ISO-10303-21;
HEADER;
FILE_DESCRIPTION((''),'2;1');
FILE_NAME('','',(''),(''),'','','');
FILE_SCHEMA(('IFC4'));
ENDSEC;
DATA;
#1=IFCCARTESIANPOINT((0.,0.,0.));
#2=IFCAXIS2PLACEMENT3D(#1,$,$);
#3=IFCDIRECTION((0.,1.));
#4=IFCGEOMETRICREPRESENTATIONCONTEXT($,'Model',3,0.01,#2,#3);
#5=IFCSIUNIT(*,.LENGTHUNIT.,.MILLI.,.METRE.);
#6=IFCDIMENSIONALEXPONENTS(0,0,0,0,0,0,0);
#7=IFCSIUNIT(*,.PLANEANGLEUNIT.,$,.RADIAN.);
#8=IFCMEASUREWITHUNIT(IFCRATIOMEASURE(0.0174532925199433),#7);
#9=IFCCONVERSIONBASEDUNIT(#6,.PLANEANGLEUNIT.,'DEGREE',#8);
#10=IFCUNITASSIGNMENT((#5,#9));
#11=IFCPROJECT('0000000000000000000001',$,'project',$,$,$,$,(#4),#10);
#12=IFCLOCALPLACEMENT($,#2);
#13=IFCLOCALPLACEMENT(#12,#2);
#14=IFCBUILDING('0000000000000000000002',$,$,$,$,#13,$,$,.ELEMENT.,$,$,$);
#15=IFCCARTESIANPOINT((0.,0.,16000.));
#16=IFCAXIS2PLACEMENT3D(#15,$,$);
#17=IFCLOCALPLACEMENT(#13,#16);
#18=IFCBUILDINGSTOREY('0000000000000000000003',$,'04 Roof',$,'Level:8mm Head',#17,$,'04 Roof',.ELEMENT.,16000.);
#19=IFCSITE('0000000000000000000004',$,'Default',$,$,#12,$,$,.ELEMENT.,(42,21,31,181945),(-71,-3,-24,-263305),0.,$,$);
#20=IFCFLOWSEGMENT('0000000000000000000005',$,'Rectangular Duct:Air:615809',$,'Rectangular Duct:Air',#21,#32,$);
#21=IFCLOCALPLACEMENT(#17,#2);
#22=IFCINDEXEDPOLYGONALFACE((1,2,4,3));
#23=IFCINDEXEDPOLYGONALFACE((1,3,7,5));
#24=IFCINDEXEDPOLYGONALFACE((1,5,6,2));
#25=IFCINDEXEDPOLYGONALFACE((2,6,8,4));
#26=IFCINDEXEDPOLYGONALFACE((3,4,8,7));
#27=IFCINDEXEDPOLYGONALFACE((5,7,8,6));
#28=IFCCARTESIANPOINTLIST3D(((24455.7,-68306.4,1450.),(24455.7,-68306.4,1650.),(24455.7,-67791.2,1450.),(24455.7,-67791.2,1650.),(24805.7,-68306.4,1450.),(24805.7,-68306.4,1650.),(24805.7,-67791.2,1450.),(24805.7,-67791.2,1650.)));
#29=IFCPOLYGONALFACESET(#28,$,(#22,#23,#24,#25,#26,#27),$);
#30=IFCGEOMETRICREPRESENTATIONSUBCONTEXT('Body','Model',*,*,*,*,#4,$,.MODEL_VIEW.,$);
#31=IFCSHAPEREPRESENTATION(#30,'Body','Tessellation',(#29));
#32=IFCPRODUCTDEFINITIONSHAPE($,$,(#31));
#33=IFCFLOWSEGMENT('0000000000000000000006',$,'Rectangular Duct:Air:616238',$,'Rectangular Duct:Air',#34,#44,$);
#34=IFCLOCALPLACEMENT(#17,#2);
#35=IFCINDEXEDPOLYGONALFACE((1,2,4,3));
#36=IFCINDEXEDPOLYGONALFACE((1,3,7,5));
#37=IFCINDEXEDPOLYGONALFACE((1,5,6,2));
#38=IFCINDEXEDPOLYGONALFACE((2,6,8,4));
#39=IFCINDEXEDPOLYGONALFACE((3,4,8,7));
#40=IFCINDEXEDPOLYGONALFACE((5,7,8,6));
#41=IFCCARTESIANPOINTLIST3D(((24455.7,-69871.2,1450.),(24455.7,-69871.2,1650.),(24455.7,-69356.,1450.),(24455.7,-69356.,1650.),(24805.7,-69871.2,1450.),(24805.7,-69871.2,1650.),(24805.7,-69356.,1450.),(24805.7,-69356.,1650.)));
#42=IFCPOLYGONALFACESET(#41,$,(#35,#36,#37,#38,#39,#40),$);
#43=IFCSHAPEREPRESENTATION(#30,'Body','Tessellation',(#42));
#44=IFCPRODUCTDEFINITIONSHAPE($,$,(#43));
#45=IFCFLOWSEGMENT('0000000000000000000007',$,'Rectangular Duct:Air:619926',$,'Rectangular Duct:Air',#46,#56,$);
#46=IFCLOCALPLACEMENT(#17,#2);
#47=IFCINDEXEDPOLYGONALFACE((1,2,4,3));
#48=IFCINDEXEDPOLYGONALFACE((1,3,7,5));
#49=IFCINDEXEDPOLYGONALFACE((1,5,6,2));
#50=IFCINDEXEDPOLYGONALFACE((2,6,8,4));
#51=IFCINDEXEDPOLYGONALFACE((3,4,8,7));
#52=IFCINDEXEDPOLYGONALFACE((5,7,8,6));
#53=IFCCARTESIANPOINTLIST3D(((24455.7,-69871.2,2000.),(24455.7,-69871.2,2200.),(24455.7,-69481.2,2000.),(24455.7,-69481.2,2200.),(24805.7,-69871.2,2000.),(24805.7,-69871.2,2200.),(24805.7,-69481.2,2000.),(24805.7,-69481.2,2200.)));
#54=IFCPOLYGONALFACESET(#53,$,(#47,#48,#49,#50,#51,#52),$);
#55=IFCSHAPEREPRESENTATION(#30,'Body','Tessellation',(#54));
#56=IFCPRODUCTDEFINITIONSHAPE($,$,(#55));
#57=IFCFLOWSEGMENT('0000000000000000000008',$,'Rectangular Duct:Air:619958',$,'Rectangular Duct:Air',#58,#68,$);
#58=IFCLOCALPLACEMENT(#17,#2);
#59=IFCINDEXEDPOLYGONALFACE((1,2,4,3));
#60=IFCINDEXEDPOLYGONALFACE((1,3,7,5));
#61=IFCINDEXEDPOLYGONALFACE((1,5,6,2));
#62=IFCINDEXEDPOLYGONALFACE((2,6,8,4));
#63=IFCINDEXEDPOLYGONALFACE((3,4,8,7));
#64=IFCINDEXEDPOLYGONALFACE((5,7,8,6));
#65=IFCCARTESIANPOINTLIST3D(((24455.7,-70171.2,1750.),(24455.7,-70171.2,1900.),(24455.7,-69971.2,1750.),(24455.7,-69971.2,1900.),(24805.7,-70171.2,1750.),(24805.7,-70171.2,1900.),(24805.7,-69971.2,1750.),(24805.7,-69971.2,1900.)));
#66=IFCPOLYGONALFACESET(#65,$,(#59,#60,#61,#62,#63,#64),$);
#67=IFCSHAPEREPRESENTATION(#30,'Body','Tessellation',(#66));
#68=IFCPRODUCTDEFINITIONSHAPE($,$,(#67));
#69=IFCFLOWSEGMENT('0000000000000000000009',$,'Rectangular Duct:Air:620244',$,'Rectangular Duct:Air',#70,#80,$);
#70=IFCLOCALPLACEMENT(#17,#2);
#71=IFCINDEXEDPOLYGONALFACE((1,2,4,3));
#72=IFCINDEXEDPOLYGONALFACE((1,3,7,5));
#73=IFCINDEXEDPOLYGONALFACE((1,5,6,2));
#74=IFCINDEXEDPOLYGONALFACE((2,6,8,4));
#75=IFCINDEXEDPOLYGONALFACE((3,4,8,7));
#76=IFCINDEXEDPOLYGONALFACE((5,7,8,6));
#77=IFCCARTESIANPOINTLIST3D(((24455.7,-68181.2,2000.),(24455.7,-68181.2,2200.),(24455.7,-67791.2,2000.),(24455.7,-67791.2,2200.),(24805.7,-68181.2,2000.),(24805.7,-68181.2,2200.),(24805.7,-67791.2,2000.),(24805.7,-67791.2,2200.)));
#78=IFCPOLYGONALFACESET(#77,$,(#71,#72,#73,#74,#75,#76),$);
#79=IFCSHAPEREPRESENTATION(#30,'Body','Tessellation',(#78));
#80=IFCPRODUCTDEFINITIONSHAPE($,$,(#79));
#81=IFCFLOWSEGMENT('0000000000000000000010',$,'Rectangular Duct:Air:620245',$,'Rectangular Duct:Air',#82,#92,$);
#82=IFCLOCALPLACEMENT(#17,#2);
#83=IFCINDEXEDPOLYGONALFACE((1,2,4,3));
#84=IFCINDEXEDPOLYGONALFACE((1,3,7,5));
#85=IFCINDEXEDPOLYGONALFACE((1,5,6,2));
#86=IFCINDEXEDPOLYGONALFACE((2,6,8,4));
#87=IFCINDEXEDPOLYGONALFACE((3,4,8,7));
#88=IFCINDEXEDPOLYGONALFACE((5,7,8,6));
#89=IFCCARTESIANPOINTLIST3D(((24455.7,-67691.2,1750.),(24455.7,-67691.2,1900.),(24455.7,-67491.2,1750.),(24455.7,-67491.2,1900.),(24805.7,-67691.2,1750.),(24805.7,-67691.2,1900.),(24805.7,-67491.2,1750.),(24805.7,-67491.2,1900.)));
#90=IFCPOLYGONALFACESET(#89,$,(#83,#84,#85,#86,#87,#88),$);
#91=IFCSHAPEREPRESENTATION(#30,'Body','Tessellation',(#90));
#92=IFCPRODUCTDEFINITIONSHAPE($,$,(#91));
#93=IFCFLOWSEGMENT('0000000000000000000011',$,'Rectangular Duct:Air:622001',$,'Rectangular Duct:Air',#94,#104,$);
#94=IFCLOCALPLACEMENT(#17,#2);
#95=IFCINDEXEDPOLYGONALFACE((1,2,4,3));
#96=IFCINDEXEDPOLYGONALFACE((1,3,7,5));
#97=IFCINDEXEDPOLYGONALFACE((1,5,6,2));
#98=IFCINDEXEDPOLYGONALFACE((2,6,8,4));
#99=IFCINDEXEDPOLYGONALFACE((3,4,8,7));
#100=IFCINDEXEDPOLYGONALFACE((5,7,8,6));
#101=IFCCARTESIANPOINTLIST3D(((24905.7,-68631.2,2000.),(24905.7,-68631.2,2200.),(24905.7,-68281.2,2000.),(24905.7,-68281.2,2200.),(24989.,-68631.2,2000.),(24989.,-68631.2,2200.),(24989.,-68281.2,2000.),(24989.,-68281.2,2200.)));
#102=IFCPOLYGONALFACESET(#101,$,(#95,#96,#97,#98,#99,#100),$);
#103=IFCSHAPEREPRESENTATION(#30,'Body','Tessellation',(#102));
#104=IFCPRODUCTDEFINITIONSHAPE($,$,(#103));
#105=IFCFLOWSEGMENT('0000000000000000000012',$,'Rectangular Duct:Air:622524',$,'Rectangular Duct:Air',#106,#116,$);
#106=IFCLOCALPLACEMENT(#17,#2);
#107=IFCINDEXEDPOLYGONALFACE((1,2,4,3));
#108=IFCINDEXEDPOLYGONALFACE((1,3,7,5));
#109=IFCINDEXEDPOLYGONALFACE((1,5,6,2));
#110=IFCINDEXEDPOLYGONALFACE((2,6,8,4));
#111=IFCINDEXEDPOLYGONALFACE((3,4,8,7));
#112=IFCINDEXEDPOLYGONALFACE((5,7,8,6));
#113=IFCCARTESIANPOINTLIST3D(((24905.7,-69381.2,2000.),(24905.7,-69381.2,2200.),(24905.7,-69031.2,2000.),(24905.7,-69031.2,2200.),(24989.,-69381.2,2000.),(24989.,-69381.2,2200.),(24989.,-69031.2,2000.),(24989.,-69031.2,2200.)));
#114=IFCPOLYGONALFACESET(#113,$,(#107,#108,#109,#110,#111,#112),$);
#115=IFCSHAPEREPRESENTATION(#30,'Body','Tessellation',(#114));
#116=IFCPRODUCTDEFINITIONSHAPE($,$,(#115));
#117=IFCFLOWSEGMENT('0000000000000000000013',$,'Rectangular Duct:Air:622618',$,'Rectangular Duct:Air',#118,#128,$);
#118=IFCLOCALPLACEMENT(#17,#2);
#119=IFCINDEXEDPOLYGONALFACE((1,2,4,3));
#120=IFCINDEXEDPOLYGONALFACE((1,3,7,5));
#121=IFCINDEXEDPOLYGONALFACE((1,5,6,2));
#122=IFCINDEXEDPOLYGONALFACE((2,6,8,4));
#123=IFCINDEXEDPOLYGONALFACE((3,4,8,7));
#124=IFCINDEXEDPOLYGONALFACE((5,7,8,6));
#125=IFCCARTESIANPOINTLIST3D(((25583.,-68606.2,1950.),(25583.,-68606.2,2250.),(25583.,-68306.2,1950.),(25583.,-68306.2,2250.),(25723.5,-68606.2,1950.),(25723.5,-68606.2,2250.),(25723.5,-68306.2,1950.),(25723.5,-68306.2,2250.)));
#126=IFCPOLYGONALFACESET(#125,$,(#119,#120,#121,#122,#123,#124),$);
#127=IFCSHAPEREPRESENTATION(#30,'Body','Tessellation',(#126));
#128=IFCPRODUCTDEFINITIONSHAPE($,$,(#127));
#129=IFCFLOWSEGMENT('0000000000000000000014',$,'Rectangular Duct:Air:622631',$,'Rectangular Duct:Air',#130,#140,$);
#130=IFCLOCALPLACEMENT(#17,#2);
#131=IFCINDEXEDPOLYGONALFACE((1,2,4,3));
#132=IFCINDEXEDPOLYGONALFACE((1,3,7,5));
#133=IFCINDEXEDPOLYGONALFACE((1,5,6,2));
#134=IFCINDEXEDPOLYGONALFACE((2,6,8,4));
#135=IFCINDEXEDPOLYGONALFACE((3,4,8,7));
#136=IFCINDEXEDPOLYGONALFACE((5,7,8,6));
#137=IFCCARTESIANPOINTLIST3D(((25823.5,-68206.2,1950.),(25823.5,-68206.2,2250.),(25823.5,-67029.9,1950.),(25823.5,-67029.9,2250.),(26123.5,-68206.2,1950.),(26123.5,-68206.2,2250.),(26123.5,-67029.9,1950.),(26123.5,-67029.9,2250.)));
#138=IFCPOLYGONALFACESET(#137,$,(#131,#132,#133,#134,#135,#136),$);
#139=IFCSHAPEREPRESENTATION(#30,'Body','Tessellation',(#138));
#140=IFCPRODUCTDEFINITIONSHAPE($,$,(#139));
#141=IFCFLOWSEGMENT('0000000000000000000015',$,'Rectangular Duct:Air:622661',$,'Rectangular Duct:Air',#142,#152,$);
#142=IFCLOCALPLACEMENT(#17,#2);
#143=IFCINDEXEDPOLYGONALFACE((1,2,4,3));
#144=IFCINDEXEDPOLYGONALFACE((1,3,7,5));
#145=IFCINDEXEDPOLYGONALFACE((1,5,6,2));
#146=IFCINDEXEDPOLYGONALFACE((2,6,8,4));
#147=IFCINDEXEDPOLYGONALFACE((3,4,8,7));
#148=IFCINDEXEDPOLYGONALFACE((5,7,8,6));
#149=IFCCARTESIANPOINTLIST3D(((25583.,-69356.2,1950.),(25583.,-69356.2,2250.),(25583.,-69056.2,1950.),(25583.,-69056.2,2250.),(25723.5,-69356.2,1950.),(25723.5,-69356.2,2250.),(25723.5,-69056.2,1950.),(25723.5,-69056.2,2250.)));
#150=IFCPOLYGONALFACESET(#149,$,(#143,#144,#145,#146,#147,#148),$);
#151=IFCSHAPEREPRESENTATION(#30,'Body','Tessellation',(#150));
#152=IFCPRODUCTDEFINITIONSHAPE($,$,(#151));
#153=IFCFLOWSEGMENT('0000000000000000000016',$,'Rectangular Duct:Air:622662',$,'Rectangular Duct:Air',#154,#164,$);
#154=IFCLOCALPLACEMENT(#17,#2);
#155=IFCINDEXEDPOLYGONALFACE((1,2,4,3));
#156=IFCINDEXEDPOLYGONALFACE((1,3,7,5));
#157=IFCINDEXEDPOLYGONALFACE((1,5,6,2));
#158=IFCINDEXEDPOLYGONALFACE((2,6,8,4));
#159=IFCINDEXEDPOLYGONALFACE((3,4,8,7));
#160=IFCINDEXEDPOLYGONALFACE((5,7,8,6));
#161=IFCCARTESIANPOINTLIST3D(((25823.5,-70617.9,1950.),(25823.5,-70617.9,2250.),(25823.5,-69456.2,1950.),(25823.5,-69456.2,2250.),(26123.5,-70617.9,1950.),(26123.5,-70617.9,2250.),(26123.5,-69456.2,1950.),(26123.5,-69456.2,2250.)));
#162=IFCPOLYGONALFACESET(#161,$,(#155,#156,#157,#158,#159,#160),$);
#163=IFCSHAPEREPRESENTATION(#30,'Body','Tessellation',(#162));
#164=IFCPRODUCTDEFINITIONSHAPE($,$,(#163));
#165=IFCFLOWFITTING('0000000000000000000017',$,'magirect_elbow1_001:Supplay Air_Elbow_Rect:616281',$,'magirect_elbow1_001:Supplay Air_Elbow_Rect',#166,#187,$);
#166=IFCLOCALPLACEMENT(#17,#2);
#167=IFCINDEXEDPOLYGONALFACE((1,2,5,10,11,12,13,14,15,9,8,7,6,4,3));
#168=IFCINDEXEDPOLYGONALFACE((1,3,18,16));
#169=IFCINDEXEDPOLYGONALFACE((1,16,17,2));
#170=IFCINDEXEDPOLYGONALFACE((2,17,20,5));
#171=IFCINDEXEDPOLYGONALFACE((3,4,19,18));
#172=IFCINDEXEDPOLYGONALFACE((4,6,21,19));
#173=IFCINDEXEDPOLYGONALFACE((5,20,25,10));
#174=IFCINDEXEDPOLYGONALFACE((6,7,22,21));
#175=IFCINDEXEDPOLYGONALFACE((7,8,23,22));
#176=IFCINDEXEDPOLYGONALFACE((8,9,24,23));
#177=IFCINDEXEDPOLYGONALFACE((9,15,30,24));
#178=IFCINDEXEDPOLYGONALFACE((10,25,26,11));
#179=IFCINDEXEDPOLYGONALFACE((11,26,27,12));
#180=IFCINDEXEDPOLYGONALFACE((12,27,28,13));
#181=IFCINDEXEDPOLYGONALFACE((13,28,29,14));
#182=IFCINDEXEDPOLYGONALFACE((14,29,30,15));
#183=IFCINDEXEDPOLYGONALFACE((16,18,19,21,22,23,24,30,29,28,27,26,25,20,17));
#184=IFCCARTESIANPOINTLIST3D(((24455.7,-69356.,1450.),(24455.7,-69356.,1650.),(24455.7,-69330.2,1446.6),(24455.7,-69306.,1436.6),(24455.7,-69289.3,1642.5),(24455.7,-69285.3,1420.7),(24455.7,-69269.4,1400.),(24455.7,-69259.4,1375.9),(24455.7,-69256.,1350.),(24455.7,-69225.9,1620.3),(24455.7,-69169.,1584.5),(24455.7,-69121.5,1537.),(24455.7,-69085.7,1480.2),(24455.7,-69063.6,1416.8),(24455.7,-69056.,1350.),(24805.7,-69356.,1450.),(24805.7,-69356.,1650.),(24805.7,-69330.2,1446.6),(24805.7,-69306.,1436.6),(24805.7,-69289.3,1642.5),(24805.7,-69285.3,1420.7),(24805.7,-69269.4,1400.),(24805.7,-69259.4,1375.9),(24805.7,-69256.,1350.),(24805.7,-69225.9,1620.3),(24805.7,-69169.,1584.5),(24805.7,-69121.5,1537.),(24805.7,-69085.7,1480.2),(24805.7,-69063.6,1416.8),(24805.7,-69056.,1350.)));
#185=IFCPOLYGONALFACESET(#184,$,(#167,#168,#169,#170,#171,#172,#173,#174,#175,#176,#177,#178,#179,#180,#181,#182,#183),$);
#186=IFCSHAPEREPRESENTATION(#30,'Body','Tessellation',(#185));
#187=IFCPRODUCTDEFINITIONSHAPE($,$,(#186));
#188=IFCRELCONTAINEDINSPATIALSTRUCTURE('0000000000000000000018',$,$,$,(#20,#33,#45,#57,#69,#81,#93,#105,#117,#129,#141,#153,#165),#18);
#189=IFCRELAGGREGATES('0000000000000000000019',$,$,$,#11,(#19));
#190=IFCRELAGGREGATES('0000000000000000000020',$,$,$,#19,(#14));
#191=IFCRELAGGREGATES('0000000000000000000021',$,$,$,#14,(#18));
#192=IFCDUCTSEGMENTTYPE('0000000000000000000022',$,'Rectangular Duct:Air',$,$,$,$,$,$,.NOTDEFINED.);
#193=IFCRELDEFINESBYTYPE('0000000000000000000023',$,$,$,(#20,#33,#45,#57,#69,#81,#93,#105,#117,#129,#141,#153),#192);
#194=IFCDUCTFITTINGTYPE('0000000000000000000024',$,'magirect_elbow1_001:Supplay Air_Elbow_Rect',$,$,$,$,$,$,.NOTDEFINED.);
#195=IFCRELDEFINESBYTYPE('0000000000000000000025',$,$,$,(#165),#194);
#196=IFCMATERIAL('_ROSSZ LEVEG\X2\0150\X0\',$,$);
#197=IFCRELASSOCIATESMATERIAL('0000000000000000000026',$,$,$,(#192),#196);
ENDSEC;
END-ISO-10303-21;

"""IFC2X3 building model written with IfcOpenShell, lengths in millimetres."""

from ifc_helpers import new_model, entity, si_unit, converted_unit, direction, frame, frame_2d, origin, origin_2d_with_axis, place, context, subcontext, project, spatial, polyline, circle_curve, parameter, trimmed, segment, composite_curve, rectangle, outline, extrude, source, transform, mapped, material, type_object, type_shapes, element, save


model = new_model("IFC2X3")

# Units and contexts
model_context = context("Model", 3, precision=0.01, world=origin(), true_north=direction((0.0, 1.0)))
body_context = subcontext(model_context, "Body", "Model", "MODEL_VIEW")
ifc_project = project(units=[si_unit("LENGTHUNIT", "METRE", prefix="MILLI"), converted_unit("PLANEANGLEUNIT", "DEGREE", entity("IfcRatioMeasure", 0.0174532925199433), si_unit("PLANEANGLEUNIT", "RADIAN"), dimensions=[0, 0, 0, 0, 0, 0, 0])], contexts=[model_context])

# Site, building, storey
site_placement = place(None, origin())
site = spatial("IfcSite", under=ifc_project, at=site_placement, Name="Default", CompositionType="ELEMENT", RefLatitude=(42, 21, 31, 181945), RefLongitude=(-71, -3, -24, -263305), RefElevation=0.0)
building_placement = place(site_placement, origin())
building = spatial("IfcBuilding", under=site, at=building_placement, CompositionType="ELEMENT")
storey_placement = place(building_placement, frame((0.0, 0.0, 16000.0)))
storey = spatial("IfcBuildingStorey", under=building, at=storey_placement, Name="04 Roof", ObjectType="Level:8mm Head", LongName="04 Roof", CompositionType="ELEMENT", Elevation=16000.0)

# Flow segments
ifc_material = material(Name="_ROSSZ LEVEGŐ")
duct_segment_type = type_object("IfcDuctSegmentType", Name="Rectangular Duct:Air", PredefinedType="NOTDEFINED", material=ifc_material)
flow_segment_1_placement = place(storey_placement, origin())
element("IfcFlowSegment", 1, at=flow_segment_1_placement, inside=storey, type_object=duct_segment_type, Name="Rectangular Duct:Air:615809", ObjectType="Rectangular Duct:Air", context=body_context, shape_type="SweptSolid", body=[
    extrude(rectangle(XDim=515.2, YDim=350.0, at=frame_2d((0.0, 0.0), x_axis=(1.0, 0.0))), frame((24630.7, -68048.8, 1450.0), z_axis=(0.0, 0.0, 1.0), x_axis=(0.0, -1.0, 0.0)), (0.0, 0.0, 1.0), 200.0),
])
flow_segment_2_placement = place(storey_placement, origin())
element("IfcFlowSegment", 2, at=flow_segment_2_placement, inside=storey, type_object=duct_segment_type, Name="Rectangular Duct:Air:616238", ObjectType="Rectangular Duct:Air", context=body_context, shape_type="SweptSolid", body=[
    extrude(rectangle(XDim=515.2, YDim=350.0, at=origin_2d_with_axis()), frame((24630.7, -69613.6, 1450.0), z_axis=(0.0, 0.0, 1.0), x_axis=(0.0, -1.0, 0.0)), (0.0, 0.0, 1.0), 200.0),
])
flow_segment_3_placement = place(storey_placement, origin())
element("IfcFlowSegment", 3, at=flow_segment_3_placement, inside=storey, type_object=duct_segment_type, Name="Rectangular Duct:Air:619926", ObjectType="Rectangular Duct:Air", context=body_context, shape_type="SweptSolid", body=[
    extrude(rectangle(XDim=390.0, YDim=350.0, at=origin_2d_with_axis()), frame((24630.7, -69676.2, 2000.0), z_axis=(0.0, 0.0, 1.0), x_axis=(0.0, -1.0, 0.0)), (0.0, 0.0, 1.0), 200.0),
])
flow_segment_4_placement = place(storey_placement, origin())
element("IfcFlowSegment", 4, at=flow_segment_4_placement, inside=storey, type_object=duct_segment_type, Name="Rectangular Duct:Air:619958", ObjectType="Rectangular Duct:Air", context=body_context, shape_type="SweptSolid", body=[
    extrude(rectangle(XDim=200.0, YDim=350.0, at=frame_2d((0.0, 0.0), x_axis=(1.0, 0.0))), frame((24630.7, -70071.2, 1750.0), z_axis=(0.0, 0.0, 1.0), x_axis=(0.0, -1.0, 0.0)), (0.0, 0.0, 1.0), 150.0),
])
flow_segment_5_placement = place(storey_placement, origin())
element("IfcFlowSegment", 5, at=flow_segment_5_placement, inside=storey, type_object=duct_segment_type, Name="Rectangular Duct:Air:620244", ObjectType="Rectangular Duct:Air", context=body_context, shape_type="SweptSolid", body=[
    extrude(rectangle(XDim=390.0, YDim=350.0, at=origin_2d_with_axis()), frame((24630.7, -67986.2, 2000.0), z_axis=(0.0, 0.0, 1.0), x_axis=(0.0, -1.0, 0.0)), (0.0, 0.0, 1.0), 200.0),
])
flow_segment_6_placement = place(storey_placement, origin())
element("IfcFlowSegment", 6, at=flow_segment_6_placement, inside=storey, type_object=duct_segment_type, Name="Rectangular Duct:Air:620245", ObjectType="Rectangular Duct:Air", context=body_context, shape_type="SweptSolid", body=[
    extrude(rectangle(XDim=200.0, YDim=350.0, at=frame_2d((0.0, 0.0), x_axis=(1.0, 0.0))), frame((24630.7, -67591.2, 1750.0), z_axis=(0.0, 0.0, 1.0), x_axis=(0.0, 1.0, 0.0)), (0.0, 0.0, 1.0), 150.0),
])
flow_segment_7_placement = place(storey_placement, origin())
element("IfcFlowSegment", 7, at=flow_segment_7_placement, inside=storey, type_object=duct_segment_type, Name="Rectangular Duct:Air:622001", ObjectType="Rectangular Duct:Air", context=body_context, shape_type="SweptSolid", body=[
    extrude(rectangle(XDim=83.3, YDim=350.0, at=frame_2d((0.0, 0.0), x_axis=(1.0, 0.0))), frame((24947.3, -68456.2, 2000.0)), (0.0, 0.0, 1.0), 200.0),
])
flow_segment_8_placement = place(storey_placement, origin())
element("IfcFlowSegment", 8, at=flow_segment_8_placement, inside=storey, type_object=duct_segment_type, Name="Rectangular Duct:Air:622524", ObjectType="Rectangular Duct:Air", context=body_context, shape_type="SweptSolid", body=[
    extrude(rectangle(XDim=83.3, YDim=350.0, at=frame_2d((0.0, 0.0), x_axis=(1.0, 0.0))), frame((24947.3, -69206.2, 2000.0)), (0.0, 0.0, 1.0), 200.0),
])
flow_segment_9_placement = place(storey_placement, origin())
element("IfcFlowSegment", 9, at=flow_segment_9_placement, inside=storey, type_object=duct_segment_type, Name="Rectangular Duct:Air:622618", ObjectType="Rectangular Duct:Air", context=body_context, shape_type="SweptSolid", body=[
    extrude(rectangle(XDim=140.5, YDim=300.0, at=frame_2d((0.0, 0.0), x_axis=(1.0, 0.0))), frame((25653.2, -68456.2, 1950.0)), (0.0, 0.0, 1.0), 300.0),
])
flow_segment_10_placement = place(storey_placement, origin())
element("IfcFlowSegment", 10, at=flow_segment_10_placement, inside=storey, type_object=duct_segment_type, Name="Rectangular Duct:Air:622631", ObjectType="Rectangular Duct:Air", context=body_context, shape_type="SweptSolid", body=[
    extrude(rectangle(XDim=1176.3, YDim=300.0, at=origin_2d_with_axis()), frame((25973.5, -67618.1, 1950.0), z_axis=(0.0, 0.0, 1.0), x_axis=(0.0, 1.0, 0.0)), (0.0, 0.0, 1.0), 300.0),
])
flow_segment_11_placement = place(storey_placement, origin())
element("IfcFlowSegment", 11, at=flow_segment_11_placement, inside=storey, type_object=duct_segment_type, Name="Rectangular Duct:Air:622661", ObjectType="Rectangular Duct:Air", context=body_context, shape_type="SweptSolid", body=[
    extrude(rectangle(XDim=140.5, YDim=300.0, at=origin_2d_with_axis()), frame((25653.2, -69206.2, 1950.0), z_axis=(0.0, 0.0, 1.0), x_axis=(-1.0, 0.0, 0.0)), (0.0, 0.0, 1.0), 300.0),
])
flow_segment_12_placement = place(storey_placement, origin())
element("IfcFlowSegment", 12, at=flow_segment_12_placement, inside=storey, type_object=duct_segment_type, Name="Rectangular Duct:Air:622662", ObjectType="Rectangular Duct:Air", context=body_context, shape_type="SweptSolid", body=[
    extrude(rectangle(XDim=1161.7, YDim=300.0, at=frame_2d((0.0, 0.0), x_axis=(1.0, 0.0))), frame((25973.5, -70037.1, 1950.0), z_axis=(0.0, 0.0, 1.0), x_axis=(0.0, -1.0, 0.0)), (0.0, 0.0, 1.0), 300.0),
])

# Flow fitting
duct_fitting_type_1 = type_object("IfcDuctFittingType", Name="magirect_elbow1_001:Supplay Air_Elbow_Rect", PredefinedType="NOTDEFINED")
shared_shape_1 = source(origin(), body_context, "Body", "SweptSolid", [
    extrude(outline(composite_curve([segment(polyline([(-200.0, -100.0), (0.0, -100.0)]), True, "CONTINUOUS"), segment(trimmed(circle_curve(frame_2d((100.0, -100.0), x_axis=(0.0, 1.0)), 100.0), [parameter(0.0)], [parameter(90.0)], True, "PARAMETER"), False, "CONTINUOUS"), segment(polyline([(100.0, 0.0), (100.0, 200.0)]), True, "CONTINUOUS"), segment(trimmed(circle_curve(frame_2d((100.0, -100.0), x_axis=(0.0, 1.0)), 300.0), [parameter(0.0)], [parameter(90.0)], True, "PARAMETER"), True, "CONTINUOUS")], self_intersect=False)), frame((-100.0, 100.0, -175.0), z_axis=(0.0, 0.0, 1.0), x_axis=(-1.0, 0.0, 0.0)), (0.0, 0.0, 1.0), 350.0),
])
type_shapes(duct_fitting_type_1, [shared_shape_1])
for number, where, z_axis, x_axis, name in (
    (13, (24630.7, -69156.0, 1550.0), (-1.0, 0.0, 0.0), (0.0, 1.0, 0.0), "magirect_elbow1_001:Supplay Air_Elbow_Rect:616281"),
):
    element("IfcFlowFitting", number, at=place(storey_placement, frame(where, z_axis=z_axis, x_axis=x_axis)), inside=storey, type_object=duct_fitting_type_1, Name=name, ObjectType="magirect_elbow1_001:Supplay Air_Elbow_Rect", context=body_context, shape_type="MappedRepresentation", body=[
        mapped(shared_shape_1, transform((0.0, 0.0, 0.0), scale=1.0)),
    ])

save(model, "model.ifc")
